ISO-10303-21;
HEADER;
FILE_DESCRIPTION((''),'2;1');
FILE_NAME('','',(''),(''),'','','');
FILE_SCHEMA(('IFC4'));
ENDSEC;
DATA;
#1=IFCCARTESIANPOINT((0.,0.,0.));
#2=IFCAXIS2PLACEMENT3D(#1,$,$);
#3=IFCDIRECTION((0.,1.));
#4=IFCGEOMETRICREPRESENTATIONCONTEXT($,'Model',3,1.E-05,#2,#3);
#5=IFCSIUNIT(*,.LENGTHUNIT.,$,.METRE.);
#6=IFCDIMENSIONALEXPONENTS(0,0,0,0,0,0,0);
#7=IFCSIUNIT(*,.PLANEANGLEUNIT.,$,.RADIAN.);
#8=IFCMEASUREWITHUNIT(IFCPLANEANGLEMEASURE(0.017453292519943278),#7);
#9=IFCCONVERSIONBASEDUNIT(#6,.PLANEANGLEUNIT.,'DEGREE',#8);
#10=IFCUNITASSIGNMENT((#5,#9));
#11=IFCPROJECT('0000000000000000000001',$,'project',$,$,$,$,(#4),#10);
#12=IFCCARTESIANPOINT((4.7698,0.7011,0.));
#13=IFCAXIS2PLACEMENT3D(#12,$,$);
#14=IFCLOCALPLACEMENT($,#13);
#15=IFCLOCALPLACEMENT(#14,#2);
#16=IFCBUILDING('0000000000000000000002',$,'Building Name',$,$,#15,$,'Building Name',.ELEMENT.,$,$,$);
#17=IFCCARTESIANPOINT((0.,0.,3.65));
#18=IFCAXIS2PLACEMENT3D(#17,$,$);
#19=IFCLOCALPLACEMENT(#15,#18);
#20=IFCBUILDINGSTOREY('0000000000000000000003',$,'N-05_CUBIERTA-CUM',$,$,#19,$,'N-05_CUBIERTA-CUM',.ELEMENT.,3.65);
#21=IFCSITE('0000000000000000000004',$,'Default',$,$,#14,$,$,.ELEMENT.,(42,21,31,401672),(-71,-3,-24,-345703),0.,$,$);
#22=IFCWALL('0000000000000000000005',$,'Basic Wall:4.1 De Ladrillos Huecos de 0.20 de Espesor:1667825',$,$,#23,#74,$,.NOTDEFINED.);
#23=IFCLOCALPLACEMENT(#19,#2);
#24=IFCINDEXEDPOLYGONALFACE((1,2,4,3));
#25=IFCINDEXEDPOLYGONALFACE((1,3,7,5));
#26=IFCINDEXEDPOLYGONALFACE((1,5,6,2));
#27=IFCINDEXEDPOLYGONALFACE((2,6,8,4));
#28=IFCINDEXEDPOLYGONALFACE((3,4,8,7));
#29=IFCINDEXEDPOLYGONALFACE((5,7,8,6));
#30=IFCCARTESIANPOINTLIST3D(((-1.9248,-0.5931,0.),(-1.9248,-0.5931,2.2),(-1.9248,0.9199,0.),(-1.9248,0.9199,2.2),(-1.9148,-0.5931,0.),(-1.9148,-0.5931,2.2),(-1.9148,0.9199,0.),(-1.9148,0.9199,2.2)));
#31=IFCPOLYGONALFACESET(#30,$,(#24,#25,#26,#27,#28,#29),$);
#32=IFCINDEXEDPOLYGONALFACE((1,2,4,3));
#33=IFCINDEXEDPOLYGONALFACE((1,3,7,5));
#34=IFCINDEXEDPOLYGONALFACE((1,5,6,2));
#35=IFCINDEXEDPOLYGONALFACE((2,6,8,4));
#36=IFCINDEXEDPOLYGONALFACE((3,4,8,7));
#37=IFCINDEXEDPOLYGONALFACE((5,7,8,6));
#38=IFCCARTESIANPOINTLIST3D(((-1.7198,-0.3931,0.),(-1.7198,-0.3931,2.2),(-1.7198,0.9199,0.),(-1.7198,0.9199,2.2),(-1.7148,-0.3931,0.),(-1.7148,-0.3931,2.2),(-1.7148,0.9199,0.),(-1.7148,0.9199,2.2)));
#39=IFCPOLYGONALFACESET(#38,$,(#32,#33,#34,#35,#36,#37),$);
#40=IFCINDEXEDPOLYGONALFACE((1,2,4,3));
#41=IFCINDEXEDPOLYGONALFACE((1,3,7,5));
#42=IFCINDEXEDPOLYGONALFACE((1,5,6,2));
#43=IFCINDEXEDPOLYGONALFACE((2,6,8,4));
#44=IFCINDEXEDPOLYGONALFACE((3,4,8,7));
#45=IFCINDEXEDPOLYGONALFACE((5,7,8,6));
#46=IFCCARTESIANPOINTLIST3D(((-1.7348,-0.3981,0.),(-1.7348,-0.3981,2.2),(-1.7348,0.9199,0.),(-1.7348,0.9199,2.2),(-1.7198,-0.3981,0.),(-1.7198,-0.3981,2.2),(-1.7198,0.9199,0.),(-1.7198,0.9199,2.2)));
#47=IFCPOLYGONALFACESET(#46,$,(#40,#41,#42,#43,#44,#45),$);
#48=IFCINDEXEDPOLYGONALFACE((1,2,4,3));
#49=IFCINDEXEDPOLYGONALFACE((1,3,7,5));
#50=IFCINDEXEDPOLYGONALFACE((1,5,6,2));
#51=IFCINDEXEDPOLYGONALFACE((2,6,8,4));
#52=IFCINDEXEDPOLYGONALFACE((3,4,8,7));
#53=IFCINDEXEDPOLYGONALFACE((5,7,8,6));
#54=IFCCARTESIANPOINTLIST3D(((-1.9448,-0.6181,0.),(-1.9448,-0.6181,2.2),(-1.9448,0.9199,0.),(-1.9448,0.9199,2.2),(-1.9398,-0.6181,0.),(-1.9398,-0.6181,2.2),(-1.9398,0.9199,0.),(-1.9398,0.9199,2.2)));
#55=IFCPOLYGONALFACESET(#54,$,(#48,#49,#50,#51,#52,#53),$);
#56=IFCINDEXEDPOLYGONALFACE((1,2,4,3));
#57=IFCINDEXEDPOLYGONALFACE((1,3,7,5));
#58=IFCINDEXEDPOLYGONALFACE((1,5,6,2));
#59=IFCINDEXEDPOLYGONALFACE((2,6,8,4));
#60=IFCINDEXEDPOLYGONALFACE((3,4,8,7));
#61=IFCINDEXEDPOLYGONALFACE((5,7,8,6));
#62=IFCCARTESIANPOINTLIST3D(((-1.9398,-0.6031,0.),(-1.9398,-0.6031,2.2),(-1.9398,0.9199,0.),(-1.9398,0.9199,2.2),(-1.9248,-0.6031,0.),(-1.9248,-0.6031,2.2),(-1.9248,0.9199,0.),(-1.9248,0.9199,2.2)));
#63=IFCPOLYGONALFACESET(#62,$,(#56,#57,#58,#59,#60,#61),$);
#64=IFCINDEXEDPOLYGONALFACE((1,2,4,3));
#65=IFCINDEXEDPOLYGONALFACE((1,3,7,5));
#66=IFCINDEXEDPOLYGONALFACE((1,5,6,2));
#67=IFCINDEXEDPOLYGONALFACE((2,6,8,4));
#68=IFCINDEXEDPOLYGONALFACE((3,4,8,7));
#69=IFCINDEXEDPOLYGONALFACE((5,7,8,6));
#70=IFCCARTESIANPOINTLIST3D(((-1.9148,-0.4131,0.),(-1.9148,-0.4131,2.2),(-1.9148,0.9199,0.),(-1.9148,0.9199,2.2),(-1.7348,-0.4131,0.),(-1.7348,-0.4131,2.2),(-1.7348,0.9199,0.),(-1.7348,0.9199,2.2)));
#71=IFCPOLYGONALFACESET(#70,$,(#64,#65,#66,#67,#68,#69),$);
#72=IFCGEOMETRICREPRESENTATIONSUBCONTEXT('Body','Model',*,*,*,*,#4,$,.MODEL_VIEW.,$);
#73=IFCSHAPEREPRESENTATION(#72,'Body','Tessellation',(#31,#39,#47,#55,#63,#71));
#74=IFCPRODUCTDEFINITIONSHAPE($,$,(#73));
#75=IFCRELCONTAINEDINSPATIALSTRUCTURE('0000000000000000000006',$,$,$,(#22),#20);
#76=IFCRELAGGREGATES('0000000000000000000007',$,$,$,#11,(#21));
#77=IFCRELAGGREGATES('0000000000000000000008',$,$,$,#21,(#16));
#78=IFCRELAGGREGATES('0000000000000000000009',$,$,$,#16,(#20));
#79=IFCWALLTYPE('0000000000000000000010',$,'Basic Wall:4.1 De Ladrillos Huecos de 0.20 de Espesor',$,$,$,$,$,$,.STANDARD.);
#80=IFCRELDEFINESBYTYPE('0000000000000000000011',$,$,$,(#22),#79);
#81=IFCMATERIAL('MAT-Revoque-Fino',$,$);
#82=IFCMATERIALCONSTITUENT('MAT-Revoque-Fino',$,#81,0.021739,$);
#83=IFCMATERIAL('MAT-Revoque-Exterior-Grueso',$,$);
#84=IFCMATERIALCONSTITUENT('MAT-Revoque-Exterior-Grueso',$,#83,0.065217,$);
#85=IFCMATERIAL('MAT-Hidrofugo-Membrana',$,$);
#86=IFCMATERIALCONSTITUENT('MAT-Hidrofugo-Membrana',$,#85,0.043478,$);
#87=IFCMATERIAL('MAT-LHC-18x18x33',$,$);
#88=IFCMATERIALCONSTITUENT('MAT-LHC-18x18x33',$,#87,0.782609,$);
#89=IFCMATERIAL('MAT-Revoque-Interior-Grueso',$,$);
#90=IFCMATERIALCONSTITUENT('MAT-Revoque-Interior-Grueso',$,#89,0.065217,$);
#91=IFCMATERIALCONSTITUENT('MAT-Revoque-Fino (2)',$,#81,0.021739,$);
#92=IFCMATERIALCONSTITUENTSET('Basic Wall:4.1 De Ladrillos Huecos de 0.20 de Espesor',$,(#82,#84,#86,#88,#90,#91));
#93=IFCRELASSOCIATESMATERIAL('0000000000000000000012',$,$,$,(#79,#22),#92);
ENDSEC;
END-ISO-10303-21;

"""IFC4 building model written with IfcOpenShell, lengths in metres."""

from ifc_helpers import new_model, entity, si_unit, converted_unit, direction, frame, origin, place, context, subcontext, project, spatial, indexed_curve, outline, extrude, material, constituent, constituent_set, type_object, element, save


model = new_model("IFC4")

# Units and contexts
model_context = context("Model", 3, precision=1e-05, world=origin(), true_north=direction((0.0, 1.0)))
body_context = subcontext(model_context, "Body", "Model", "MODEL_VIEW")
ifc_project = project(units=[si_unit("LENGTHUNIT", "METRE"), converted_unit("PLANEANGLEUNIT", "DEGREE", entity("IfcPlaneAngleMeasure", 0.017453292519943278), si_unit("PLANEANGLEUNIT", "RADIAN"), dimensions=[0, 0, 0, 0, 0, 0, 0])], contexts=[model_context])

# Site, building, storey
site_placement = place(None, frame((4.7698, 0.7011, 0.0)))
site = spatial("IfcSite", under=ifc_project, at=site_placement, Name="Default", CompositionType="ELEMENT", RefLatitude=(42, 21, 31, 401672), RefLongitude=(-71, -3, -24, -345703), RefElevation=0.0)
building_placement = place(site_placement, origin())
building = spatial("IfcBuilding", under=site, at=building_placement, Name="Building Name", LongName="Building Name", CompositionType="ELEMENT")
storey_placement = place(building_placement, frame((0.0, 0.0, 3.65)))
storey = spatial("IfcBuildingStorey", under=building, at=storey_placement, Name="N-05_CUBIERTA-CUM", LongName="N-05_CUBIERTA-CUM", CompositionType="ELEMENT", Elevation=3.65)

# Wall
ifc_material_1 = material(Name="MAT-Revoque-Fino")
ifc_constituent_1 = constituent(ifc_material_1, Name="MAT-Revoque-Fino", fraction=0.021739)
ifc_material_2 = material(Name="MAT-Revoque-Exterior-Grueso")
ifc_constituent_2 = constituent(ifc_material_2, Name="MAT-Revoque-Exterior-Grueso", fraction=0.065217)
ifc_material_3 = material(Name="MAT-Hidrofugo-Membrana")
ifc_constituent_3 = constituent(ifc_material_3, Name="MAT-Hidrofugo-Membrana", fraction=0.043478)
ifc_material_4 = material(Name="MAT-LHC-18x18x33")
ifc_constituent_4 = constituent(ifc_material_4, Name="MAT-LHC-18x18x33", fraction=0.782609)
ifc_material_5 = material(Name="MAT-Revoque-Interior-Grueso")
ifc_constituent_5 = constituent(ifc_material_5, Name="MAT-Revoque-Interior-Grueso", fraction=0.065217)
ifc_constituent_6 = constituent(ifc_material_1, Name="MAT-Revoque-Fino (2)", fraction=0.021739)
ifc_constituent_set = constituent_set(constituents=[ifc_constituent_1, ifc_constituent_2, ifc_constituent_3, ifc_constituent_4, ifc_constituent_5, ifc_constituent_6], Name="Basic Wall:4.1 De Ladrillos Huecos de 0.20 de Espesor")
wall_type = type_object("IfcWallType", Name="Basic Wall:4.1 De Ladrillos Huecos de 0.20 de Espesor", PredefinedType="STANDARD", material=ifc_constituent_set)
wall_placement = place(storey_placement, frame((-1.8298, -0.3931, 0.0), z_axis=(0.0, 0.0, 1.0), x_axis=(0.0, 1.0, 0.0)))
element("IfcWall", 1, at=wall_placement, inside=storey, type_object=wall_type, material=ifc_constituent_set, Name="Basic Wall:4.1 De Ladrillos Huecos de 0.20 de Espesor:1667825", PredefinedType="NOTDEFINED", context=body_context, shape_type="SweptSolid", body=[
    extrude(outline(indexed_curve([(-0.005, -0.7565), (0.005, -0.7565), (0.005, 0.7565), (-0.005, 0.7565), (-0.005, -0.7565)], self_intersect=False)), frame((0.5565, 0.09, 0.0), z_axis=(0.0, 0.0, 1.0), x_axis=(0.0, -1.0, 0.0)), (0.0, 0.0, 1.0), 2.2),
    extrude(outline(indexed_curve([(-0.0025, -0.6565), (0.0025, -0.6565), (0.0025, 0.6565), (-0.0025, 0.6565), (-0.0025, -0.6565)], self_intersect=False)), frame((0.6565, -0.1125, 0.0), z_axis=(0.0, 0.0, 1.0), x_axis=(0.0, -1.0, 0.0)), (0.0, 0.0, 1.0), 2.2),
    extrude(outline(indexed_curve([(-0.0075, -0.659), (0.0075, -0.659), (0.0075, 0.659), (-0.0075, 0.659), (-0.0075, -0.659)], self_intersect=False)), frame((0.654, -0.1025, 0.0), z_axis=(0.0, 0.0, 1.0), x_axis=(0.0, 1.0, 0.0)), (0.0, 0.0, 1.0), 2.2),
    extrude(outline(indexed_curve([(-0.0025, -0.769), (0.0025, -0.769), (0.0025, 0.769), (-0.0025, 0.769), (-0.0025, -0.769)], self_intersect=False)), frame((0.544, 0.1125, 0.0), z_axis=(0.0, 0.0, 1.0), x_axis=(0.0, 1.0, 0.0)), (0.0, 0.0, 1.0), 2.2),
    extrude(outline(indexed_curve([(-0.0075, -0.7615), (0.0075, -0.7615), (0.0075, 0.7615), (-0.0075, 0.7615), (-0.0075, -0.7615)], self_intersect=False)), frame((0.5515, 0.1025, 0.0), z_axis=(0.0, 0.0, 1.0), x_axis=(0.0, 1.0, 0.0)), (0.0, 0.0, 1.0), 2.2),
    extrude(outline(indexed_curve([(-0.09, -0.6665), (0.09, -0.6665), (0.09, 0.6665), (-0.09, 0.6665), (-0.09, -0.6665)], self_intersect=False)), frame((0.6465, -0.005, 0.0), z_axis=(0.0, 0.0, 1.0), x_axis=(0.0, -1.0, 0.0)), (0.0, 0.0, 1.0), 2.2),
])

save(model, "model.ifc")
